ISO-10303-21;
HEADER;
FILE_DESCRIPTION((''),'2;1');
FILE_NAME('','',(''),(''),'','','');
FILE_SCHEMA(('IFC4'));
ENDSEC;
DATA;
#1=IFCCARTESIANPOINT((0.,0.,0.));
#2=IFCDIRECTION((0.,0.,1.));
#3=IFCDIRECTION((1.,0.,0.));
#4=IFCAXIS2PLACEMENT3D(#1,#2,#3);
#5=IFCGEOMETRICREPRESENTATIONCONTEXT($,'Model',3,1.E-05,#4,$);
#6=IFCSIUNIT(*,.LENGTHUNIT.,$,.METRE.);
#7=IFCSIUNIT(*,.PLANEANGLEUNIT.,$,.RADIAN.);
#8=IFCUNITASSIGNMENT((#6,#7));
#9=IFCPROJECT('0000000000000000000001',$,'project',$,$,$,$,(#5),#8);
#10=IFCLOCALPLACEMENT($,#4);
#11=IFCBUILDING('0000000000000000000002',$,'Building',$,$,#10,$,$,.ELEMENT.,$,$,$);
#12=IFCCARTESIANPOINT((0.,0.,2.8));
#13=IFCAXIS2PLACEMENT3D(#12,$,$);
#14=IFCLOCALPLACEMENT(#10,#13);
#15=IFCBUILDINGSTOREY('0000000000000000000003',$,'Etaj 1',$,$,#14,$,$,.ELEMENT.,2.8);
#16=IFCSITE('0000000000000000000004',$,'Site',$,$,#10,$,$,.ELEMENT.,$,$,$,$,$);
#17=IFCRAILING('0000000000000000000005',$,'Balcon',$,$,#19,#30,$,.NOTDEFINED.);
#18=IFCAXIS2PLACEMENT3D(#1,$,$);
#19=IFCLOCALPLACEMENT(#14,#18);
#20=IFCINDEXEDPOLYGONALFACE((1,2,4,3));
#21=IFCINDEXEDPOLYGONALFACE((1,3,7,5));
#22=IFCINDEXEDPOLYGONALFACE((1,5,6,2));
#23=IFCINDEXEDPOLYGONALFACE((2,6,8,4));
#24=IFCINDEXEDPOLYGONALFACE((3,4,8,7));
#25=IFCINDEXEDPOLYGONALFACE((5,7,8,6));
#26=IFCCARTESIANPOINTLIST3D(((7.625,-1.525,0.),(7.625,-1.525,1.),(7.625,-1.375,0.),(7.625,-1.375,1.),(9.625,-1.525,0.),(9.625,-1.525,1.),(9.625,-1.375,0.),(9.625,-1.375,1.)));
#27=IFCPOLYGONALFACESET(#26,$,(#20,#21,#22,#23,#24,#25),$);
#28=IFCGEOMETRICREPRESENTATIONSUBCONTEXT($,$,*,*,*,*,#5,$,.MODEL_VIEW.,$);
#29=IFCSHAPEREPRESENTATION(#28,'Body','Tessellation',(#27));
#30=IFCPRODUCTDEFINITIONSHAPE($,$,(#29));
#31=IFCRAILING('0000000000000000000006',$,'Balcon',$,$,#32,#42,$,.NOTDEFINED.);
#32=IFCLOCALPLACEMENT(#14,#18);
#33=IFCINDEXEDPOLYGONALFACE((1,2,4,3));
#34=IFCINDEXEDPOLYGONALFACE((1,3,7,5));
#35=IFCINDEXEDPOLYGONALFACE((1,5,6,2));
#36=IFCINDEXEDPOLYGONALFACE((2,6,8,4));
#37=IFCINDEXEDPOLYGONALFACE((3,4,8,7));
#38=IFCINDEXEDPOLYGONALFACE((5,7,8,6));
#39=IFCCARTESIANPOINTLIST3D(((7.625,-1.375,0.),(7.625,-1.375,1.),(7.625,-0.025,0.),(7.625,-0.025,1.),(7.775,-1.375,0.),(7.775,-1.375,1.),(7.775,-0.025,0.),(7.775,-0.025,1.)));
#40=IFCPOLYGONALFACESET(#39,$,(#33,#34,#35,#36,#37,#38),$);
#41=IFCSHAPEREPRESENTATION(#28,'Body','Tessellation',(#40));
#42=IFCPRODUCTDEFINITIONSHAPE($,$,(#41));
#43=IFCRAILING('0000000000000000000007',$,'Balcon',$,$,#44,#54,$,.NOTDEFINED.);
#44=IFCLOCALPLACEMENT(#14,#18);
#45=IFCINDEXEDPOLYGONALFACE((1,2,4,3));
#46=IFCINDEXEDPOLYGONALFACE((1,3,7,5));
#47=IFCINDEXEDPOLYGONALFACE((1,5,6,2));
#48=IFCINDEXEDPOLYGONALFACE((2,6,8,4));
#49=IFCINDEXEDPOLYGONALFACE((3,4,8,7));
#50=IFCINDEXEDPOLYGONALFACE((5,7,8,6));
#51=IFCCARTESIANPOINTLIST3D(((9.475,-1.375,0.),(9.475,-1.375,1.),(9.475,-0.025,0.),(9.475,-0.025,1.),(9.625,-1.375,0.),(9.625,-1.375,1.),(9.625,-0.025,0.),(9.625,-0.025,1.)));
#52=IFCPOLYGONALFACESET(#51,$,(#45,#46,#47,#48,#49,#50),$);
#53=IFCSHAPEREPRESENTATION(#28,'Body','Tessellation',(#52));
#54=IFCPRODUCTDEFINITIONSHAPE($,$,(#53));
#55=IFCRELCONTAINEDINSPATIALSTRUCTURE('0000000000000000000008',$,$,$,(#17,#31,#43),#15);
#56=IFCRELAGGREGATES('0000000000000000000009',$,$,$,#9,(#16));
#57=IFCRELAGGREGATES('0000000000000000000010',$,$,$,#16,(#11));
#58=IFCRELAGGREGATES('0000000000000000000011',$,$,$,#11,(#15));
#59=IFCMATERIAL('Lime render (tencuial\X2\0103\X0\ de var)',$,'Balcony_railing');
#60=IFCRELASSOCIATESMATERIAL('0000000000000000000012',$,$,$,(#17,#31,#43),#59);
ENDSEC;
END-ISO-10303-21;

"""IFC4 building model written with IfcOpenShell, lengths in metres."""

from ifc_helpers import new_model, si_unit, frame, origin, origin_with_axes, place, context, subcontext, project, spatial, polyline, outline, extrude, material, element, save


model = new_model("IFC4")

# Units and contexts
model_context = context("Model", 3, precision=1e-05, world=origin_with_axes())
sub_context = subcontext(model_context, None, None, "MODEL_VIEW")
ifc_project = project(units=[si_unit("LENGTHUNIT", "METRE"), si_unit("PLANEANGLEUNIT", "RADIAN")], contexts=[model_context])

# Site, building, storey
placement = place(None, origin_with_axes())
site = spatial("IfcSite", under=ifc_project, at=placement, Name="Site", CompositionType="ELEMENT")
building = spatial("IfcBuilding", under=site, at=placement, Name="Building", CompositionType="ELEMENT")
storey_placement = place(placement, frame((0.0, 0.0, 2.8)))
storey = spatial("IfcBuildingStorey", under=building, at=storey_placement, Name="Etaj 1", CompositionType="ELEMENT", Elevation=2.8)

# Railings
ifc_material_1 = material(Name="Lime render (tencuială de var)", Category="Balcony_railing")
railing_placement = place(storey_placement, frame((7.625, -1.525, 0.0), z_axis=(0.0, 0.0, 1.0), x_axis=(1.0, 0.0, 0.0)))
element("IfcRailing", 1, at=railing_placement, inside=storey, material=ifc_material_1, Name="Balcon", PredefinedType="NOTDEFINED", context=sub_context, shape_type="SweptSolid", body=[
    extrude(outline(polyline([(0.0, 0.0), (2.0, 0.0), (2.0, 0.15), (0.0, 0.15), (0.0, 0.0)])), origin(), (0.0, 0.0, 1.0), 1.0),
])
for number, where, z_axis, x_axis, name in (
    (2, (7.625, -1.375, 0.0), (0.0, 0.0, 1.0), (1.0, 0.0, 0.0), "Balcon"),
    (3, (9.475, -1.375, 0.0), (0.0, 0.0, 1.0), (1.0, 0.0, 0.0), "Balcon"),
):
    element("IfcRailing", number, at=place(storey_placement, frame(where, z_axis=z_axis, x_axis=x_axis)), inside=storey, material=ifc_material_1, Name=name, PredefinedType="NOTDEFINED", context=sub_context, shape_type="SweptSolid", body=[
        extrude(outline(polyline([(0.0, 0.0), (0.15, 0.0), (0.15, 1.35), (0.0, 1.35), (0.0, 0.0)])), origin(), (0.0, 0.0, 1.0), 1.0),
    ])

save(model, "model.ifc")
